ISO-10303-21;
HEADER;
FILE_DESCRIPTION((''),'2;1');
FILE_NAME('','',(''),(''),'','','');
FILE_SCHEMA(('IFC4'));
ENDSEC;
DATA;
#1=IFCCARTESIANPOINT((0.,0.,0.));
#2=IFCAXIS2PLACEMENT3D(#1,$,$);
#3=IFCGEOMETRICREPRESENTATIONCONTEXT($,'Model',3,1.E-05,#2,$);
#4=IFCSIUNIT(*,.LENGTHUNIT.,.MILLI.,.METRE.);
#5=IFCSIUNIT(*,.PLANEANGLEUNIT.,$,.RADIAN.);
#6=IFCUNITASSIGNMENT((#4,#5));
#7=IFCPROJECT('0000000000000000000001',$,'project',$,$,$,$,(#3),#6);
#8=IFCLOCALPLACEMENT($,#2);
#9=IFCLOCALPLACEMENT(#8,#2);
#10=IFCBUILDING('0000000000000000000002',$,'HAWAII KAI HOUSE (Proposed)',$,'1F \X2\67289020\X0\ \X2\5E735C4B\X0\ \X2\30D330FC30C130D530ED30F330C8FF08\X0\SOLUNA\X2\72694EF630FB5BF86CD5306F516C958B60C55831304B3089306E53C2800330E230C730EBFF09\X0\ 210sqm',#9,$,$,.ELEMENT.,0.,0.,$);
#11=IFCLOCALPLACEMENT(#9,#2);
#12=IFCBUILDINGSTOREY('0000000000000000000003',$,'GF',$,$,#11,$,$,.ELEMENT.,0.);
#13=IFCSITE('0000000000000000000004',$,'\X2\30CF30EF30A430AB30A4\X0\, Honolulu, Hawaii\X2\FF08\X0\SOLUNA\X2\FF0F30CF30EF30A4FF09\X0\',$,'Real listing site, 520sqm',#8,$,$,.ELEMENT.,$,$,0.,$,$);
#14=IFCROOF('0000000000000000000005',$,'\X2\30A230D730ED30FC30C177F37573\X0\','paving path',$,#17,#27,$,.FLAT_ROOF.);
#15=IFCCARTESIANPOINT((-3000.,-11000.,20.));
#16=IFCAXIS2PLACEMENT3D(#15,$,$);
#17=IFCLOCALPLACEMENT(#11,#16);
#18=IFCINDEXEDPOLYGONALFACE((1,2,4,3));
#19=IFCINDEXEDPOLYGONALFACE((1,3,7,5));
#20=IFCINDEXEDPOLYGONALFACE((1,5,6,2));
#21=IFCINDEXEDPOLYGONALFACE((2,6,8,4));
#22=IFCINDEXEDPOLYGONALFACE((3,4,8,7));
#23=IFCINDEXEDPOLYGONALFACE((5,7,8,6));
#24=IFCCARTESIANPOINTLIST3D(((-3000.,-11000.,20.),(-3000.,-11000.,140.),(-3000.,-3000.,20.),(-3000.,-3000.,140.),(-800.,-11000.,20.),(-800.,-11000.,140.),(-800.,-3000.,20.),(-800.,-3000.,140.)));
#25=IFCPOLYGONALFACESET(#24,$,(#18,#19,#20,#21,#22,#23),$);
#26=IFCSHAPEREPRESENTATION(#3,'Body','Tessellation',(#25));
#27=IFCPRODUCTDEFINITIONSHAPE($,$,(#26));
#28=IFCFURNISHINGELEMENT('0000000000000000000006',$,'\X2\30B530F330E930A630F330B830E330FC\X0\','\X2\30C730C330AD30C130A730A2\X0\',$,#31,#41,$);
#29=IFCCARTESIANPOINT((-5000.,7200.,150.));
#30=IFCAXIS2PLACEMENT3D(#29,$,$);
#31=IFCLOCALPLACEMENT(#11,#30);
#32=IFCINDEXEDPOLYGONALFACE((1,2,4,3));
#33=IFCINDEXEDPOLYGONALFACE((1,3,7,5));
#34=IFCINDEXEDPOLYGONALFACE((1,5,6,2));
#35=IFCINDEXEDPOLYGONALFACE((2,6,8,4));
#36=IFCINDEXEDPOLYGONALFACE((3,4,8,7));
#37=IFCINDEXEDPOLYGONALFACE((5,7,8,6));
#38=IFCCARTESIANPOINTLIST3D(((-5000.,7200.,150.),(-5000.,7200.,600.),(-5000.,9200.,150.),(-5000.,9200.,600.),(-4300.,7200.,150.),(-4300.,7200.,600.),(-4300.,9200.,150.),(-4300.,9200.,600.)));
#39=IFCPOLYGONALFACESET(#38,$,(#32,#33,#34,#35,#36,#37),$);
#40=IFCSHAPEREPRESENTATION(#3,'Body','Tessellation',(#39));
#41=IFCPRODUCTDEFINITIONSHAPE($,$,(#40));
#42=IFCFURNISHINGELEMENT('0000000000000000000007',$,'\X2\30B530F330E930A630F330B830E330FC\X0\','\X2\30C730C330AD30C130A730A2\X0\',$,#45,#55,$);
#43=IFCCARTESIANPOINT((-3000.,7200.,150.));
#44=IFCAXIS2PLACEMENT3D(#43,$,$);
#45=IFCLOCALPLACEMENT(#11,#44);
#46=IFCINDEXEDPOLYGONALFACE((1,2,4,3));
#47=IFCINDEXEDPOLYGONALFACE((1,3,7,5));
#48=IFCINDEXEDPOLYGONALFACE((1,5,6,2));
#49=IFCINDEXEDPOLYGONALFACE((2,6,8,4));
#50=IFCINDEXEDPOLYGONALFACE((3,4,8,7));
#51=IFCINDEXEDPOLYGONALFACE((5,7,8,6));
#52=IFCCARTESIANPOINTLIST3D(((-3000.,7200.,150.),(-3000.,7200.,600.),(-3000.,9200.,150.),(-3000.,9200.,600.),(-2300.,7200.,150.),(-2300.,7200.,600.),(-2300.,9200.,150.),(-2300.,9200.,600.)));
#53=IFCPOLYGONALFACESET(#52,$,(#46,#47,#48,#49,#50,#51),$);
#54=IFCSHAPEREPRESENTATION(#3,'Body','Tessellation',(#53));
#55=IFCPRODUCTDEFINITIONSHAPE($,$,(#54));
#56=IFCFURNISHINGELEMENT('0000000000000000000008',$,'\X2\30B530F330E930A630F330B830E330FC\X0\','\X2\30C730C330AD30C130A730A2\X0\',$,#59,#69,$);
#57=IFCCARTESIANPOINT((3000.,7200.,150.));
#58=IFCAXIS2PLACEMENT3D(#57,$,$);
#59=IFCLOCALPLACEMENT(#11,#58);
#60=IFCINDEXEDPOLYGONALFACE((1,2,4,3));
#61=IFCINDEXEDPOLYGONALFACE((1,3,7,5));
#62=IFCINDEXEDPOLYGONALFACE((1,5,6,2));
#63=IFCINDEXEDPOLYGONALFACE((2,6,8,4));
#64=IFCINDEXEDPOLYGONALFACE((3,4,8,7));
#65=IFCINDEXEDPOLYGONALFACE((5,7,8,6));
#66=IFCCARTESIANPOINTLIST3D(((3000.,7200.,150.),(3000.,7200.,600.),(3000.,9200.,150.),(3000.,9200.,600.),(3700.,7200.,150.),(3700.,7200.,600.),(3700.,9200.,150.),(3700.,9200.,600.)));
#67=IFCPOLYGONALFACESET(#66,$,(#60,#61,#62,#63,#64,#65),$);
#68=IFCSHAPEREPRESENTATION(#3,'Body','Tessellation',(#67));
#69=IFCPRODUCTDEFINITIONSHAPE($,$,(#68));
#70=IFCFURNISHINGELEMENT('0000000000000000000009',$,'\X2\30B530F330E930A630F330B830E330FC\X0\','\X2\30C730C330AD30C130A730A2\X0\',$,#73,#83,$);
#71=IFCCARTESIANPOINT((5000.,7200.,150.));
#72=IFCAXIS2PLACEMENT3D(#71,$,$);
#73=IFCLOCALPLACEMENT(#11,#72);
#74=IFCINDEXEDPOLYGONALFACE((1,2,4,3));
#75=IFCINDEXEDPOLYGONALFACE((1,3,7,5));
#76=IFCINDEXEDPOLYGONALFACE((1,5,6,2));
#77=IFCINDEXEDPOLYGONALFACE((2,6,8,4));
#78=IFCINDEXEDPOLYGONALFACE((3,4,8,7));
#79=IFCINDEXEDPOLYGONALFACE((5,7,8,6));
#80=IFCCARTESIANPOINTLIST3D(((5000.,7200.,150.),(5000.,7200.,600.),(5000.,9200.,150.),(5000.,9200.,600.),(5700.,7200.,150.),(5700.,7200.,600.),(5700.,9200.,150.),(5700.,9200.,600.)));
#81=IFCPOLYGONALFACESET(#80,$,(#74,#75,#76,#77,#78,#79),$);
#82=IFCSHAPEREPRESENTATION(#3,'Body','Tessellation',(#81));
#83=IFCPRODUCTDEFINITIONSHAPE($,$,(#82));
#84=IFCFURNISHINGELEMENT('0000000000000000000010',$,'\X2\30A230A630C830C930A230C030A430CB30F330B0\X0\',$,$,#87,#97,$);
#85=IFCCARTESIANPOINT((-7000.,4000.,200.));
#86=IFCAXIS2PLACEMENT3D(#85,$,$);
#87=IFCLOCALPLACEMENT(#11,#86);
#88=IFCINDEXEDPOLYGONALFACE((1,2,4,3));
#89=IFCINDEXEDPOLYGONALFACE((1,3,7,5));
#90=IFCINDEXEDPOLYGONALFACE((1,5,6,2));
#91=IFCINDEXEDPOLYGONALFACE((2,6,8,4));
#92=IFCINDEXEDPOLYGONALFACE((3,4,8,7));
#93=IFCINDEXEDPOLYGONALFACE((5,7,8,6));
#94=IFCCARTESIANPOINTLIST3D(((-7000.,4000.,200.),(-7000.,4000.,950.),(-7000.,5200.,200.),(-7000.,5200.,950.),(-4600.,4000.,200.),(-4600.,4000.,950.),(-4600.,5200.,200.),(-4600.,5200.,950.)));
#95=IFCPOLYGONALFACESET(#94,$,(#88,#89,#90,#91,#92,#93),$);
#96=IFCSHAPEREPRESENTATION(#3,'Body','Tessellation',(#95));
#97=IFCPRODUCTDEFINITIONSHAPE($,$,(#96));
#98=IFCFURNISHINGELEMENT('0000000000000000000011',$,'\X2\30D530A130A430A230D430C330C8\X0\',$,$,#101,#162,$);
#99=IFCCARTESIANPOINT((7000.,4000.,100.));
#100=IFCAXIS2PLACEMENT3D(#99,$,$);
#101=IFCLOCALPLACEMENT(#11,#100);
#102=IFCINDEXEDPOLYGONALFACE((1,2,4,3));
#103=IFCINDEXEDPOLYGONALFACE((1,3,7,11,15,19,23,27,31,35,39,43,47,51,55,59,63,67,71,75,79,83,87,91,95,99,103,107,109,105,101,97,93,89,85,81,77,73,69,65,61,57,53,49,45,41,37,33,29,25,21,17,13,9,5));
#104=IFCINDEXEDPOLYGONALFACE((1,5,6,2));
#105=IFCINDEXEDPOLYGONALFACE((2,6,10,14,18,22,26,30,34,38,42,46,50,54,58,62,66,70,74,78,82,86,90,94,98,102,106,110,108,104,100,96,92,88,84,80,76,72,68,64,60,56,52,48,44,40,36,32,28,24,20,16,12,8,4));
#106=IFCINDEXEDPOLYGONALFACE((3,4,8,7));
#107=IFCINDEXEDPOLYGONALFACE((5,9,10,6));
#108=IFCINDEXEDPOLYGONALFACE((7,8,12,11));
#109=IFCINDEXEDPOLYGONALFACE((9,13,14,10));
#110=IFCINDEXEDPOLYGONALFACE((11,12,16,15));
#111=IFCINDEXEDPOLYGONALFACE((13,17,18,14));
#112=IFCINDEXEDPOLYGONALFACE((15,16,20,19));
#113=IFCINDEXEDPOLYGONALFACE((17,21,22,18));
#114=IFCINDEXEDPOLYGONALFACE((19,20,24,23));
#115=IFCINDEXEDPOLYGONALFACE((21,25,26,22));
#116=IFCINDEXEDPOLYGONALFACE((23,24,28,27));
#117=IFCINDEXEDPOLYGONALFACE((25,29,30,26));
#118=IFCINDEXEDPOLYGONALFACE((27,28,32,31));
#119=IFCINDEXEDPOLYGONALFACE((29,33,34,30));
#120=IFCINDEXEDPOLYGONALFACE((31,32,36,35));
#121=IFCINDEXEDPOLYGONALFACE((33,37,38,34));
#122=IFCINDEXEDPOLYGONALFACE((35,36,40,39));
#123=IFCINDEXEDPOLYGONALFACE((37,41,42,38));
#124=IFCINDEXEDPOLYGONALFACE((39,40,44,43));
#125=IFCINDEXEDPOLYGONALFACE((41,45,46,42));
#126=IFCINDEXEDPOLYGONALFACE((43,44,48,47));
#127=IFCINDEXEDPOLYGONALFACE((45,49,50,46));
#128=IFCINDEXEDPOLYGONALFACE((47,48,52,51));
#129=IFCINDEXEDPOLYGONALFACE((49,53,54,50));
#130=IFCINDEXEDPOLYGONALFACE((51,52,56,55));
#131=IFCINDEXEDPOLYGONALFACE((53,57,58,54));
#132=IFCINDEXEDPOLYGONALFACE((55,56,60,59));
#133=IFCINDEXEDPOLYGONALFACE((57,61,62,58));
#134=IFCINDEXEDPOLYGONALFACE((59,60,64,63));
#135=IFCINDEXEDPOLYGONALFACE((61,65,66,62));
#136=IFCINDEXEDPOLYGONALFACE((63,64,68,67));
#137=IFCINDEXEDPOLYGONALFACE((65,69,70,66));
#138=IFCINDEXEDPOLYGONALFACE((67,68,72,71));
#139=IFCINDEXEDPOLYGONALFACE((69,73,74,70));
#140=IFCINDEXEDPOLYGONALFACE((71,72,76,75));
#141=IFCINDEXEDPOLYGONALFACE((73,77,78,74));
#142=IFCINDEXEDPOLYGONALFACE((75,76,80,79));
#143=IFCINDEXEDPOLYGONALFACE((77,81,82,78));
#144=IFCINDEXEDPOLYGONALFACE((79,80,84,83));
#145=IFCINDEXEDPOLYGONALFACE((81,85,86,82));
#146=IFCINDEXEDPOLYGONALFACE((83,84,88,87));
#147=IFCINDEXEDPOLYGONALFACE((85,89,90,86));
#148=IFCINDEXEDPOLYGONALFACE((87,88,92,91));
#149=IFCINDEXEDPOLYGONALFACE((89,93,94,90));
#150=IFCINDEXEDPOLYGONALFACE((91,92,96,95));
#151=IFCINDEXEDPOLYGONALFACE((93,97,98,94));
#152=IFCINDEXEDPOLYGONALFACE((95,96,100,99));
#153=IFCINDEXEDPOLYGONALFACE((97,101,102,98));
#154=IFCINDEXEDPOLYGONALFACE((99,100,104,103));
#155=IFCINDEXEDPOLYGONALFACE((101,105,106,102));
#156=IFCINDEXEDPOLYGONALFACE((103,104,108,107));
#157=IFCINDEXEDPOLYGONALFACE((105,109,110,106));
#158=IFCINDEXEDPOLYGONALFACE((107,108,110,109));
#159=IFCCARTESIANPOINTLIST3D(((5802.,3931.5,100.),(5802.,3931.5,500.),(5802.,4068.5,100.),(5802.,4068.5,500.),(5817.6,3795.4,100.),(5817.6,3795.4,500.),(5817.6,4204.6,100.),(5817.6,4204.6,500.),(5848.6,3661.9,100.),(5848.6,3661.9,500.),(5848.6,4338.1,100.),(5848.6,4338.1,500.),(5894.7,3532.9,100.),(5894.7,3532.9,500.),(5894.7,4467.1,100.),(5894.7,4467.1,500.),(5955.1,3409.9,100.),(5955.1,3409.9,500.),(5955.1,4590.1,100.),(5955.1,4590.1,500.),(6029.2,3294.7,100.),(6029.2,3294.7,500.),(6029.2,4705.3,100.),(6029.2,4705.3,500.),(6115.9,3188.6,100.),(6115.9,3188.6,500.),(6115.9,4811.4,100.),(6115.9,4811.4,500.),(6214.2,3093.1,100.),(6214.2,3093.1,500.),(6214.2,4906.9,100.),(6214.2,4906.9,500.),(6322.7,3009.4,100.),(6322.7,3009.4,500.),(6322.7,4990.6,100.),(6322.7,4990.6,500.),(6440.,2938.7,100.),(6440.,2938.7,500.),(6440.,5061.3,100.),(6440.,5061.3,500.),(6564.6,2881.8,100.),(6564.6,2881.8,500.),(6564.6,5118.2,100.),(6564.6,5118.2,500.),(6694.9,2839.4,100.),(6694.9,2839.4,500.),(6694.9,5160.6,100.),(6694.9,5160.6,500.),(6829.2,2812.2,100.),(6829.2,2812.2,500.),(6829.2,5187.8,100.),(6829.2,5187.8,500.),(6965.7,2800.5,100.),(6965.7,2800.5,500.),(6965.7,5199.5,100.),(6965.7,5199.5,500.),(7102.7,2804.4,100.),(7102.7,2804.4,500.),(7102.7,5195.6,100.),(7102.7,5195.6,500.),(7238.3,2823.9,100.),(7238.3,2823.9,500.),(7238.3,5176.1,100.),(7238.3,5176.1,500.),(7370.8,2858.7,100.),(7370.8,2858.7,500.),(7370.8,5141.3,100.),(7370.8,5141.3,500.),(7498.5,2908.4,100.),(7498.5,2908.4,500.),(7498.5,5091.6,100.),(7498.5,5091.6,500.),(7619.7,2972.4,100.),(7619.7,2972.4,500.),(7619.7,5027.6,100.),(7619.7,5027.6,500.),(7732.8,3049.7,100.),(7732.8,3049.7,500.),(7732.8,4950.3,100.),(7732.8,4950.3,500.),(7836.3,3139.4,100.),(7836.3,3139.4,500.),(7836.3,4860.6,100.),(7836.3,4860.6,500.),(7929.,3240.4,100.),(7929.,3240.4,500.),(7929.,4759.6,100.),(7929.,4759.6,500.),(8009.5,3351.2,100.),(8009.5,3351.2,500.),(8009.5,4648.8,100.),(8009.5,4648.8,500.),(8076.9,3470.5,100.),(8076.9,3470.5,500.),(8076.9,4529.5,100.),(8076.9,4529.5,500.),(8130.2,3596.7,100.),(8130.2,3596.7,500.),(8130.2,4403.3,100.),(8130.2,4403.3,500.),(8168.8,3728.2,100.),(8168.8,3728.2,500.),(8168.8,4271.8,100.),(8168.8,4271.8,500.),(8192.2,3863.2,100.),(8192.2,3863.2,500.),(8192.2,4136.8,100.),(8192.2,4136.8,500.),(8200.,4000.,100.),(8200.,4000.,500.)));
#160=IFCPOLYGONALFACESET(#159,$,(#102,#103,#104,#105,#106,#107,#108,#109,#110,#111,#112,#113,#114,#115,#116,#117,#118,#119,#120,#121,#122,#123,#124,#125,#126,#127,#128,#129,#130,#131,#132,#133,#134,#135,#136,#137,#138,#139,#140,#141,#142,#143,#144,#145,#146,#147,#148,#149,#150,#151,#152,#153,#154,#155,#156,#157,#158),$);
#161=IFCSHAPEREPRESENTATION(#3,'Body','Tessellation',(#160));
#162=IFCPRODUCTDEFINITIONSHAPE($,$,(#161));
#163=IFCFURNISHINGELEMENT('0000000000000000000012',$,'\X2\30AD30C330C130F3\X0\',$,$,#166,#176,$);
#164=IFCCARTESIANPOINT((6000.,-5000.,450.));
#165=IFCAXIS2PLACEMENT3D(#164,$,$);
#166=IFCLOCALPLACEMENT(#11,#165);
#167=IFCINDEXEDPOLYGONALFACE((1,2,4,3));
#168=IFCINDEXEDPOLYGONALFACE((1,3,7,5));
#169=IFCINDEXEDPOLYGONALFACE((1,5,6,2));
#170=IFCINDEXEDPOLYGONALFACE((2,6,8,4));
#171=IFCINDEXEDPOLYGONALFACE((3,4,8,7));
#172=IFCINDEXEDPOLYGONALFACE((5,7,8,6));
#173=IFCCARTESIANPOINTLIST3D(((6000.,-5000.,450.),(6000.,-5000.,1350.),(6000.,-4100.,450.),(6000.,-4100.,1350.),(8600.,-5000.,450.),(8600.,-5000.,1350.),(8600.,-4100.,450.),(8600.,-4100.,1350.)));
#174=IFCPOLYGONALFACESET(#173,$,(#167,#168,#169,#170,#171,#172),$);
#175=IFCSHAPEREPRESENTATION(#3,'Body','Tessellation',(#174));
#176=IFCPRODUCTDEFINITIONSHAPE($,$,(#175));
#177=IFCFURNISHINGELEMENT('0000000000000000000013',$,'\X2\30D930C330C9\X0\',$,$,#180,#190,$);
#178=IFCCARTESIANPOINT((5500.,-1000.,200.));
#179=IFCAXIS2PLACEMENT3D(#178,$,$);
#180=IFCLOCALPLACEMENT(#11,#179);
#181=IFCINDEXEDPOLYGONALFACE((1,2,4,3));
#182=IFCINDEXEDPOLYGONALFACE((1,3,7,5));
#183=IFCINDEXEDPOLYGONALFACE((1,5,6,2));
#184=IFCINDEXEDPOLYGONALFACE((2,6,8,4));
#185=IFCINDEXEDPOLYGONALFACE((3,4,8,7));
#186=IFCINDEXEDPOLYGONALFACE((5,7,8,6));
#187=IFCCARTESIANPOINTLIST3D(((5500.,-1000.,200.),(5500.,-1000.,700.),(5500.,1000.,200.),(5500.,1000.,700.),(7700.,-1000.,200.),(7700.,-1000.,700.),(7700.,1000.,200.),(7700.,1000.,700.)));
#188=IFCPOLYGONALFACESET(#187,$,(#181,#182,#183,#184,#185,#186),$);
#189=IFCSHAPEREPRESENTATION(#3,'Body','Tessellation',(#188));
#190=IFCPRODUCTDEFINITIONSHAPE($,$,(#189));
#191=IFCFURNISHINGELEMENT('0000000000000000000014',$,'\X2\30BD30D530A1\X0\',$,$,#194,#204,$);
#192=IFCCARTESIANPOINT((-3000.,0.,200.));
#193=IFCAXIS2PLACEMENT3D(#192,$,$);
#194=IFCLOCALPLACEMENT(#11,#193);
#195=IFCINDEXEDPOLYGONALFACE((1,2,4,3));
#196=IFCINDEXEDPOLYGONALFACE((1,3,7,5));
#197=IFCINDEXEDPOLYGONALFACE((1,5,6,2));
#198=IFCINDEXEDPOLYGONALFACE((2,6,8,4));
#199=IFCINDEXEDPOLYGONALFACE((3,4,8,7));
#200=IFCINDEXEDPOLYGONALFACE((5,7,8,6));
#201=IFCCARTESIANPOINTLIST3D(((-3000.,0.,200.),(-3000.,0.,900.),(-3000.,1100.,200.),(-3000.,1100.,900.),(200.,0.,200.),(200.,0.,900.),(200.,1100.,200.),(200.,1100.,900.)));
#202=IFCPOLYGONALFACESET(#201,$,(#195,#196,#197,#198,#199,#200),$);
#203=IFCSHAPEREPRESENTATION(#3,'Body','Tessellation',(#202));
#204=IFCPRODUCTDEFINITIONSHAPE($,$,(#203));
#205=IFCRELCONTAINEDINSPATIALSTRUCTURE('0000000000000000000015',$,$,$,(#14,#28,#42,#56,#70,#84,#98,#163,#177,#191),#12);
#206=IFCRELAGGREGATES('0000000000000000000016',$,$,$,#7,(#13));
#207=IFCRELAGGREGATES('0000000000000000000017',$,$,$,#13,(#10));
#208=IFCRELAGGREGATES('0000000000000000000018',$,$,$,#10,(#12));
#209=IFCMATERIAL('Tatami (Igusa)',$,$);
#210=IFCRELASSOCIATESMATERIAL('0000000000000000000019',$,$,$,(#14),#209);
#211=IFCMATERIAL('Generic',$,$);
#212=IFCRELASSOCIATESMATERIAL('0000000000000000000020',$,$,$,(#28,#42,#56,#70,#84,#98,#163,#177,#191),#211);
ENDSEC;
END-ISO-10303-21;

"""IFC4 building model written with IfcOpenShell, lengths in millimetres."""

from ifc_helpers import new_model, si_unit, frame, frame_2d, origin, origin_2d, place, context, project, spatial, rectangle, circle, extrude, material, element, save


model = new_model("IFC4")

# Units and contexts
model_context = context("Model", 3, precision=1e-05, world=origin())
ifc_project = project(units=[si_unit("LENGTHUNIT", "METRE", prefix="MILLI"), si_unit("PLANEANGLEUNIT", "RADIAN")], contexts=[model_context])

# Site, building, storey
site_placement = place(None, origin())
site = spatial("IfcSite", under=ifc_project, at=site_placement, Name="ハワイカイ, Honolulu, Hawaii（SOLUNA／ハワイ）", ObjectType="Real listing site, 520sqm", CompositionType="ELEMENT", RefElevation=0.0)
building_placement = place(site_placement, origin())
building = spatial("IfcBuilding", under=site, at=building_placement, Name="HAWAII KAI HOUSE (Proposed)", ObjectType="1F 木造 平屋 ビーチフロント（SOLUNA物件・寸法は公開情報からの参考モデル） 210sqm", CompositionType="ELEMENT", ElevationOfRefHeight=0.0, ElevationOfTerrain=0.0)
storey_placement = place(building_placement, origin())
storey = spatial("IfcBuildingStorey", under=building, at=storey_placement, Name="GF", CompositionType="ELEMENT", Elevation=0.0)

# Shared definitions
ifc_material_1 = material(Name="Generic")

# Roof
ifc_material_2 = material(Name="Tatami (Igusa)")
roof_1_placement = place(storey_placement, frame((-3000.0, -11000.0, 20.0)))
element("IfcRoof", 1, at=roof_1_placement, inside=storey, material=ifc_material_2, Name="アプローチ石畳", Description="paving path", PredefinedType="FLAT_ROOF", context=model_context, shape_type="SweptSolid", body=[
    extrude(rectangle(XDim=2200.0, YDim=8000.0, at=frame_2d((1100.0, 4000.0))), frame((-3000.0, -11000.0, 20.0)), (0.0, 0.0, 1.0), 120.0),
])

# Furnishing elements
furnishing_1_placement = place(storey_placement, frame((-5000.0, 7200.0, 150.0)))
element("IfcFurnishingElement", 2, at=furnishing_1_placement, inside=storey, material=ifc_material_1, Name="サンラウンジャー", Description="デッキチェア", context=model_context, shape_type="SweptSolid", body=[
    extrude(rectangle(XDim=700.0, YDim=2000.0, at=frame_2d((350.0, 1000.0))), frame((-5000.0, 7200.0, 150.0)), (0.0, 0.0, 1.0), 450.0),
])
furnishing_2_placement = place(storey_placement, frame((-3000.0, 7200.0, 150.0)))
element("IfcFurnishingElement", 3, at=furnishing_2_placement, inside=storey, material=ifc_material_1, Name="サンラウンジャー", Description="デッキチェア", context=model_context, shape_type="SweptSolid", body=[
    extrude(rectangle(XDim=700.0, YDim=2000.0, at=frame_2d((350.0, 1000.0))), frame((-3000.0, 7200.0, 150.0)), (0.0, 0.0, 1.0), 450.0),
])
furnishing_3_placement = place(storey_placement, frame((3000.0, 7200.0, 150.0)))
element("IfcFurnishingElement", 4, at=furnishing_3_placement, inside=storey, material=ifc_material_1, Name="サンラウンジャー", Description="デッキチェア", context=model_context, shape_type="SweptSolid", body=[
    extrude(rectangle(XDim=700.0, YDim=2000.0, at=frame_2d((350.0, 1000.0))), frame((3000.0, 7200.0, 150.0)), (0.0, 0.0, 1.0), 450.0),
])
furnishing_4_placement = place(storey_placement, frame((5000.0, 7200.0, 150.0)))
element("IfcFurnishingElement", 5, at=furnishing_4_placement, inside=storey, material=ifc_material_1, Name="サンラウンジャー", Description="デッキチェア", context=model_context, shape_type="SweptSolid", body=[
    extrude(rectangle(XDim=700.0, YDim=2000.0, at=frame_2d((350.0, 1000.0))), frame((5000.0, 7200.0, 150.0)), (0.0, 0.0, 1.0), 450.0),
])
furnishing_5_placement = place(storey_placement, frame((-7000.0, 4000.0, 200.0)))
element("IfcFurnishingElement", 6, at=furnishing_5_placement, inside=storey, material=ifc_material_1, Name="アウトドアダイニング", context=model_context, shape_type="SweptSolid", body=[
    extrude(rectangle(XDim=2400.0, YDim=1200.0, at=frame_2d((1200.0, 600.0))), frame((-7000.0, 4000.0, 200.0)), (0.0, 0.0, 1.0), 750.0),
])
furnishing_6_placement = place(storey_placement, frame((7000.0, 4000.0, 100.0)))
element("IfcFurnishingElement", 7, at=furnishing_6_placement, inside=storey, material=ifc_material_1, Name="ファイアピット", context=model_context, shape_type="SweptSolid", body=[
    extrude(circle(Radius=1200.0, at=origin_2d()), frame((7000.0, 4000.0, 100.0)), (0.0, 0.0, 1.0), 400.0),
])
furnishing_7_placement = place(storey_placement, frame((6000.0, -5000.0, 450.0)))
element("IfcFurnishingElement", 8, at=furnishing_7_placement, inside=storey, material=ifc_material_1, Name="キッチン", context=model_context, shape_type="SweptSolid", body=[
    extrude(rectangle(XDim=2600.0, YDim=900.0, at=frame_2d((1300.0, 450.0))), frame((6000.0, -5000.0, 450.0)), (0.0, 0.0, 1.0), 900.0),
])
furnishing_8_placement = place(storey_placement, frame((5500.0, -1000.0, 200.0)))
element("IfcFurnishingElement", 9, at=furnishing_8_placement, inside=storey, material=ifc_material_1, Name="ベッド", context=model_context, shape_type="SweptSolid", body=[
    extrude(rectangle(XDim=2200.0, YDim=2000.0, at=frame_2d((1100.0, 1000.0))), frame((5500.0, -1000.0, 200.0)), (0.0, 0.0, 1.0), 500.0),
])
furnishing_9_placement = place(storey_placement, frame((-3000.0, 0.0, 200.0)))
element("IfcFurnishingElement", 10, at=furnishing_9_placement, inside=storey, material=ifc_material_1, Name="ソファ", context=model_context, shape_type="SweptSolid", body=[
    extrude(rectangle(XDim=3200.0, YDim=1100.0, at=frame_2d((1600.0, 550.0))), frame((-3000.0, 0.0, 200.0)), (0.0, 0.0, 1.0), 700.0),
])

save(model, "model.ifc")
